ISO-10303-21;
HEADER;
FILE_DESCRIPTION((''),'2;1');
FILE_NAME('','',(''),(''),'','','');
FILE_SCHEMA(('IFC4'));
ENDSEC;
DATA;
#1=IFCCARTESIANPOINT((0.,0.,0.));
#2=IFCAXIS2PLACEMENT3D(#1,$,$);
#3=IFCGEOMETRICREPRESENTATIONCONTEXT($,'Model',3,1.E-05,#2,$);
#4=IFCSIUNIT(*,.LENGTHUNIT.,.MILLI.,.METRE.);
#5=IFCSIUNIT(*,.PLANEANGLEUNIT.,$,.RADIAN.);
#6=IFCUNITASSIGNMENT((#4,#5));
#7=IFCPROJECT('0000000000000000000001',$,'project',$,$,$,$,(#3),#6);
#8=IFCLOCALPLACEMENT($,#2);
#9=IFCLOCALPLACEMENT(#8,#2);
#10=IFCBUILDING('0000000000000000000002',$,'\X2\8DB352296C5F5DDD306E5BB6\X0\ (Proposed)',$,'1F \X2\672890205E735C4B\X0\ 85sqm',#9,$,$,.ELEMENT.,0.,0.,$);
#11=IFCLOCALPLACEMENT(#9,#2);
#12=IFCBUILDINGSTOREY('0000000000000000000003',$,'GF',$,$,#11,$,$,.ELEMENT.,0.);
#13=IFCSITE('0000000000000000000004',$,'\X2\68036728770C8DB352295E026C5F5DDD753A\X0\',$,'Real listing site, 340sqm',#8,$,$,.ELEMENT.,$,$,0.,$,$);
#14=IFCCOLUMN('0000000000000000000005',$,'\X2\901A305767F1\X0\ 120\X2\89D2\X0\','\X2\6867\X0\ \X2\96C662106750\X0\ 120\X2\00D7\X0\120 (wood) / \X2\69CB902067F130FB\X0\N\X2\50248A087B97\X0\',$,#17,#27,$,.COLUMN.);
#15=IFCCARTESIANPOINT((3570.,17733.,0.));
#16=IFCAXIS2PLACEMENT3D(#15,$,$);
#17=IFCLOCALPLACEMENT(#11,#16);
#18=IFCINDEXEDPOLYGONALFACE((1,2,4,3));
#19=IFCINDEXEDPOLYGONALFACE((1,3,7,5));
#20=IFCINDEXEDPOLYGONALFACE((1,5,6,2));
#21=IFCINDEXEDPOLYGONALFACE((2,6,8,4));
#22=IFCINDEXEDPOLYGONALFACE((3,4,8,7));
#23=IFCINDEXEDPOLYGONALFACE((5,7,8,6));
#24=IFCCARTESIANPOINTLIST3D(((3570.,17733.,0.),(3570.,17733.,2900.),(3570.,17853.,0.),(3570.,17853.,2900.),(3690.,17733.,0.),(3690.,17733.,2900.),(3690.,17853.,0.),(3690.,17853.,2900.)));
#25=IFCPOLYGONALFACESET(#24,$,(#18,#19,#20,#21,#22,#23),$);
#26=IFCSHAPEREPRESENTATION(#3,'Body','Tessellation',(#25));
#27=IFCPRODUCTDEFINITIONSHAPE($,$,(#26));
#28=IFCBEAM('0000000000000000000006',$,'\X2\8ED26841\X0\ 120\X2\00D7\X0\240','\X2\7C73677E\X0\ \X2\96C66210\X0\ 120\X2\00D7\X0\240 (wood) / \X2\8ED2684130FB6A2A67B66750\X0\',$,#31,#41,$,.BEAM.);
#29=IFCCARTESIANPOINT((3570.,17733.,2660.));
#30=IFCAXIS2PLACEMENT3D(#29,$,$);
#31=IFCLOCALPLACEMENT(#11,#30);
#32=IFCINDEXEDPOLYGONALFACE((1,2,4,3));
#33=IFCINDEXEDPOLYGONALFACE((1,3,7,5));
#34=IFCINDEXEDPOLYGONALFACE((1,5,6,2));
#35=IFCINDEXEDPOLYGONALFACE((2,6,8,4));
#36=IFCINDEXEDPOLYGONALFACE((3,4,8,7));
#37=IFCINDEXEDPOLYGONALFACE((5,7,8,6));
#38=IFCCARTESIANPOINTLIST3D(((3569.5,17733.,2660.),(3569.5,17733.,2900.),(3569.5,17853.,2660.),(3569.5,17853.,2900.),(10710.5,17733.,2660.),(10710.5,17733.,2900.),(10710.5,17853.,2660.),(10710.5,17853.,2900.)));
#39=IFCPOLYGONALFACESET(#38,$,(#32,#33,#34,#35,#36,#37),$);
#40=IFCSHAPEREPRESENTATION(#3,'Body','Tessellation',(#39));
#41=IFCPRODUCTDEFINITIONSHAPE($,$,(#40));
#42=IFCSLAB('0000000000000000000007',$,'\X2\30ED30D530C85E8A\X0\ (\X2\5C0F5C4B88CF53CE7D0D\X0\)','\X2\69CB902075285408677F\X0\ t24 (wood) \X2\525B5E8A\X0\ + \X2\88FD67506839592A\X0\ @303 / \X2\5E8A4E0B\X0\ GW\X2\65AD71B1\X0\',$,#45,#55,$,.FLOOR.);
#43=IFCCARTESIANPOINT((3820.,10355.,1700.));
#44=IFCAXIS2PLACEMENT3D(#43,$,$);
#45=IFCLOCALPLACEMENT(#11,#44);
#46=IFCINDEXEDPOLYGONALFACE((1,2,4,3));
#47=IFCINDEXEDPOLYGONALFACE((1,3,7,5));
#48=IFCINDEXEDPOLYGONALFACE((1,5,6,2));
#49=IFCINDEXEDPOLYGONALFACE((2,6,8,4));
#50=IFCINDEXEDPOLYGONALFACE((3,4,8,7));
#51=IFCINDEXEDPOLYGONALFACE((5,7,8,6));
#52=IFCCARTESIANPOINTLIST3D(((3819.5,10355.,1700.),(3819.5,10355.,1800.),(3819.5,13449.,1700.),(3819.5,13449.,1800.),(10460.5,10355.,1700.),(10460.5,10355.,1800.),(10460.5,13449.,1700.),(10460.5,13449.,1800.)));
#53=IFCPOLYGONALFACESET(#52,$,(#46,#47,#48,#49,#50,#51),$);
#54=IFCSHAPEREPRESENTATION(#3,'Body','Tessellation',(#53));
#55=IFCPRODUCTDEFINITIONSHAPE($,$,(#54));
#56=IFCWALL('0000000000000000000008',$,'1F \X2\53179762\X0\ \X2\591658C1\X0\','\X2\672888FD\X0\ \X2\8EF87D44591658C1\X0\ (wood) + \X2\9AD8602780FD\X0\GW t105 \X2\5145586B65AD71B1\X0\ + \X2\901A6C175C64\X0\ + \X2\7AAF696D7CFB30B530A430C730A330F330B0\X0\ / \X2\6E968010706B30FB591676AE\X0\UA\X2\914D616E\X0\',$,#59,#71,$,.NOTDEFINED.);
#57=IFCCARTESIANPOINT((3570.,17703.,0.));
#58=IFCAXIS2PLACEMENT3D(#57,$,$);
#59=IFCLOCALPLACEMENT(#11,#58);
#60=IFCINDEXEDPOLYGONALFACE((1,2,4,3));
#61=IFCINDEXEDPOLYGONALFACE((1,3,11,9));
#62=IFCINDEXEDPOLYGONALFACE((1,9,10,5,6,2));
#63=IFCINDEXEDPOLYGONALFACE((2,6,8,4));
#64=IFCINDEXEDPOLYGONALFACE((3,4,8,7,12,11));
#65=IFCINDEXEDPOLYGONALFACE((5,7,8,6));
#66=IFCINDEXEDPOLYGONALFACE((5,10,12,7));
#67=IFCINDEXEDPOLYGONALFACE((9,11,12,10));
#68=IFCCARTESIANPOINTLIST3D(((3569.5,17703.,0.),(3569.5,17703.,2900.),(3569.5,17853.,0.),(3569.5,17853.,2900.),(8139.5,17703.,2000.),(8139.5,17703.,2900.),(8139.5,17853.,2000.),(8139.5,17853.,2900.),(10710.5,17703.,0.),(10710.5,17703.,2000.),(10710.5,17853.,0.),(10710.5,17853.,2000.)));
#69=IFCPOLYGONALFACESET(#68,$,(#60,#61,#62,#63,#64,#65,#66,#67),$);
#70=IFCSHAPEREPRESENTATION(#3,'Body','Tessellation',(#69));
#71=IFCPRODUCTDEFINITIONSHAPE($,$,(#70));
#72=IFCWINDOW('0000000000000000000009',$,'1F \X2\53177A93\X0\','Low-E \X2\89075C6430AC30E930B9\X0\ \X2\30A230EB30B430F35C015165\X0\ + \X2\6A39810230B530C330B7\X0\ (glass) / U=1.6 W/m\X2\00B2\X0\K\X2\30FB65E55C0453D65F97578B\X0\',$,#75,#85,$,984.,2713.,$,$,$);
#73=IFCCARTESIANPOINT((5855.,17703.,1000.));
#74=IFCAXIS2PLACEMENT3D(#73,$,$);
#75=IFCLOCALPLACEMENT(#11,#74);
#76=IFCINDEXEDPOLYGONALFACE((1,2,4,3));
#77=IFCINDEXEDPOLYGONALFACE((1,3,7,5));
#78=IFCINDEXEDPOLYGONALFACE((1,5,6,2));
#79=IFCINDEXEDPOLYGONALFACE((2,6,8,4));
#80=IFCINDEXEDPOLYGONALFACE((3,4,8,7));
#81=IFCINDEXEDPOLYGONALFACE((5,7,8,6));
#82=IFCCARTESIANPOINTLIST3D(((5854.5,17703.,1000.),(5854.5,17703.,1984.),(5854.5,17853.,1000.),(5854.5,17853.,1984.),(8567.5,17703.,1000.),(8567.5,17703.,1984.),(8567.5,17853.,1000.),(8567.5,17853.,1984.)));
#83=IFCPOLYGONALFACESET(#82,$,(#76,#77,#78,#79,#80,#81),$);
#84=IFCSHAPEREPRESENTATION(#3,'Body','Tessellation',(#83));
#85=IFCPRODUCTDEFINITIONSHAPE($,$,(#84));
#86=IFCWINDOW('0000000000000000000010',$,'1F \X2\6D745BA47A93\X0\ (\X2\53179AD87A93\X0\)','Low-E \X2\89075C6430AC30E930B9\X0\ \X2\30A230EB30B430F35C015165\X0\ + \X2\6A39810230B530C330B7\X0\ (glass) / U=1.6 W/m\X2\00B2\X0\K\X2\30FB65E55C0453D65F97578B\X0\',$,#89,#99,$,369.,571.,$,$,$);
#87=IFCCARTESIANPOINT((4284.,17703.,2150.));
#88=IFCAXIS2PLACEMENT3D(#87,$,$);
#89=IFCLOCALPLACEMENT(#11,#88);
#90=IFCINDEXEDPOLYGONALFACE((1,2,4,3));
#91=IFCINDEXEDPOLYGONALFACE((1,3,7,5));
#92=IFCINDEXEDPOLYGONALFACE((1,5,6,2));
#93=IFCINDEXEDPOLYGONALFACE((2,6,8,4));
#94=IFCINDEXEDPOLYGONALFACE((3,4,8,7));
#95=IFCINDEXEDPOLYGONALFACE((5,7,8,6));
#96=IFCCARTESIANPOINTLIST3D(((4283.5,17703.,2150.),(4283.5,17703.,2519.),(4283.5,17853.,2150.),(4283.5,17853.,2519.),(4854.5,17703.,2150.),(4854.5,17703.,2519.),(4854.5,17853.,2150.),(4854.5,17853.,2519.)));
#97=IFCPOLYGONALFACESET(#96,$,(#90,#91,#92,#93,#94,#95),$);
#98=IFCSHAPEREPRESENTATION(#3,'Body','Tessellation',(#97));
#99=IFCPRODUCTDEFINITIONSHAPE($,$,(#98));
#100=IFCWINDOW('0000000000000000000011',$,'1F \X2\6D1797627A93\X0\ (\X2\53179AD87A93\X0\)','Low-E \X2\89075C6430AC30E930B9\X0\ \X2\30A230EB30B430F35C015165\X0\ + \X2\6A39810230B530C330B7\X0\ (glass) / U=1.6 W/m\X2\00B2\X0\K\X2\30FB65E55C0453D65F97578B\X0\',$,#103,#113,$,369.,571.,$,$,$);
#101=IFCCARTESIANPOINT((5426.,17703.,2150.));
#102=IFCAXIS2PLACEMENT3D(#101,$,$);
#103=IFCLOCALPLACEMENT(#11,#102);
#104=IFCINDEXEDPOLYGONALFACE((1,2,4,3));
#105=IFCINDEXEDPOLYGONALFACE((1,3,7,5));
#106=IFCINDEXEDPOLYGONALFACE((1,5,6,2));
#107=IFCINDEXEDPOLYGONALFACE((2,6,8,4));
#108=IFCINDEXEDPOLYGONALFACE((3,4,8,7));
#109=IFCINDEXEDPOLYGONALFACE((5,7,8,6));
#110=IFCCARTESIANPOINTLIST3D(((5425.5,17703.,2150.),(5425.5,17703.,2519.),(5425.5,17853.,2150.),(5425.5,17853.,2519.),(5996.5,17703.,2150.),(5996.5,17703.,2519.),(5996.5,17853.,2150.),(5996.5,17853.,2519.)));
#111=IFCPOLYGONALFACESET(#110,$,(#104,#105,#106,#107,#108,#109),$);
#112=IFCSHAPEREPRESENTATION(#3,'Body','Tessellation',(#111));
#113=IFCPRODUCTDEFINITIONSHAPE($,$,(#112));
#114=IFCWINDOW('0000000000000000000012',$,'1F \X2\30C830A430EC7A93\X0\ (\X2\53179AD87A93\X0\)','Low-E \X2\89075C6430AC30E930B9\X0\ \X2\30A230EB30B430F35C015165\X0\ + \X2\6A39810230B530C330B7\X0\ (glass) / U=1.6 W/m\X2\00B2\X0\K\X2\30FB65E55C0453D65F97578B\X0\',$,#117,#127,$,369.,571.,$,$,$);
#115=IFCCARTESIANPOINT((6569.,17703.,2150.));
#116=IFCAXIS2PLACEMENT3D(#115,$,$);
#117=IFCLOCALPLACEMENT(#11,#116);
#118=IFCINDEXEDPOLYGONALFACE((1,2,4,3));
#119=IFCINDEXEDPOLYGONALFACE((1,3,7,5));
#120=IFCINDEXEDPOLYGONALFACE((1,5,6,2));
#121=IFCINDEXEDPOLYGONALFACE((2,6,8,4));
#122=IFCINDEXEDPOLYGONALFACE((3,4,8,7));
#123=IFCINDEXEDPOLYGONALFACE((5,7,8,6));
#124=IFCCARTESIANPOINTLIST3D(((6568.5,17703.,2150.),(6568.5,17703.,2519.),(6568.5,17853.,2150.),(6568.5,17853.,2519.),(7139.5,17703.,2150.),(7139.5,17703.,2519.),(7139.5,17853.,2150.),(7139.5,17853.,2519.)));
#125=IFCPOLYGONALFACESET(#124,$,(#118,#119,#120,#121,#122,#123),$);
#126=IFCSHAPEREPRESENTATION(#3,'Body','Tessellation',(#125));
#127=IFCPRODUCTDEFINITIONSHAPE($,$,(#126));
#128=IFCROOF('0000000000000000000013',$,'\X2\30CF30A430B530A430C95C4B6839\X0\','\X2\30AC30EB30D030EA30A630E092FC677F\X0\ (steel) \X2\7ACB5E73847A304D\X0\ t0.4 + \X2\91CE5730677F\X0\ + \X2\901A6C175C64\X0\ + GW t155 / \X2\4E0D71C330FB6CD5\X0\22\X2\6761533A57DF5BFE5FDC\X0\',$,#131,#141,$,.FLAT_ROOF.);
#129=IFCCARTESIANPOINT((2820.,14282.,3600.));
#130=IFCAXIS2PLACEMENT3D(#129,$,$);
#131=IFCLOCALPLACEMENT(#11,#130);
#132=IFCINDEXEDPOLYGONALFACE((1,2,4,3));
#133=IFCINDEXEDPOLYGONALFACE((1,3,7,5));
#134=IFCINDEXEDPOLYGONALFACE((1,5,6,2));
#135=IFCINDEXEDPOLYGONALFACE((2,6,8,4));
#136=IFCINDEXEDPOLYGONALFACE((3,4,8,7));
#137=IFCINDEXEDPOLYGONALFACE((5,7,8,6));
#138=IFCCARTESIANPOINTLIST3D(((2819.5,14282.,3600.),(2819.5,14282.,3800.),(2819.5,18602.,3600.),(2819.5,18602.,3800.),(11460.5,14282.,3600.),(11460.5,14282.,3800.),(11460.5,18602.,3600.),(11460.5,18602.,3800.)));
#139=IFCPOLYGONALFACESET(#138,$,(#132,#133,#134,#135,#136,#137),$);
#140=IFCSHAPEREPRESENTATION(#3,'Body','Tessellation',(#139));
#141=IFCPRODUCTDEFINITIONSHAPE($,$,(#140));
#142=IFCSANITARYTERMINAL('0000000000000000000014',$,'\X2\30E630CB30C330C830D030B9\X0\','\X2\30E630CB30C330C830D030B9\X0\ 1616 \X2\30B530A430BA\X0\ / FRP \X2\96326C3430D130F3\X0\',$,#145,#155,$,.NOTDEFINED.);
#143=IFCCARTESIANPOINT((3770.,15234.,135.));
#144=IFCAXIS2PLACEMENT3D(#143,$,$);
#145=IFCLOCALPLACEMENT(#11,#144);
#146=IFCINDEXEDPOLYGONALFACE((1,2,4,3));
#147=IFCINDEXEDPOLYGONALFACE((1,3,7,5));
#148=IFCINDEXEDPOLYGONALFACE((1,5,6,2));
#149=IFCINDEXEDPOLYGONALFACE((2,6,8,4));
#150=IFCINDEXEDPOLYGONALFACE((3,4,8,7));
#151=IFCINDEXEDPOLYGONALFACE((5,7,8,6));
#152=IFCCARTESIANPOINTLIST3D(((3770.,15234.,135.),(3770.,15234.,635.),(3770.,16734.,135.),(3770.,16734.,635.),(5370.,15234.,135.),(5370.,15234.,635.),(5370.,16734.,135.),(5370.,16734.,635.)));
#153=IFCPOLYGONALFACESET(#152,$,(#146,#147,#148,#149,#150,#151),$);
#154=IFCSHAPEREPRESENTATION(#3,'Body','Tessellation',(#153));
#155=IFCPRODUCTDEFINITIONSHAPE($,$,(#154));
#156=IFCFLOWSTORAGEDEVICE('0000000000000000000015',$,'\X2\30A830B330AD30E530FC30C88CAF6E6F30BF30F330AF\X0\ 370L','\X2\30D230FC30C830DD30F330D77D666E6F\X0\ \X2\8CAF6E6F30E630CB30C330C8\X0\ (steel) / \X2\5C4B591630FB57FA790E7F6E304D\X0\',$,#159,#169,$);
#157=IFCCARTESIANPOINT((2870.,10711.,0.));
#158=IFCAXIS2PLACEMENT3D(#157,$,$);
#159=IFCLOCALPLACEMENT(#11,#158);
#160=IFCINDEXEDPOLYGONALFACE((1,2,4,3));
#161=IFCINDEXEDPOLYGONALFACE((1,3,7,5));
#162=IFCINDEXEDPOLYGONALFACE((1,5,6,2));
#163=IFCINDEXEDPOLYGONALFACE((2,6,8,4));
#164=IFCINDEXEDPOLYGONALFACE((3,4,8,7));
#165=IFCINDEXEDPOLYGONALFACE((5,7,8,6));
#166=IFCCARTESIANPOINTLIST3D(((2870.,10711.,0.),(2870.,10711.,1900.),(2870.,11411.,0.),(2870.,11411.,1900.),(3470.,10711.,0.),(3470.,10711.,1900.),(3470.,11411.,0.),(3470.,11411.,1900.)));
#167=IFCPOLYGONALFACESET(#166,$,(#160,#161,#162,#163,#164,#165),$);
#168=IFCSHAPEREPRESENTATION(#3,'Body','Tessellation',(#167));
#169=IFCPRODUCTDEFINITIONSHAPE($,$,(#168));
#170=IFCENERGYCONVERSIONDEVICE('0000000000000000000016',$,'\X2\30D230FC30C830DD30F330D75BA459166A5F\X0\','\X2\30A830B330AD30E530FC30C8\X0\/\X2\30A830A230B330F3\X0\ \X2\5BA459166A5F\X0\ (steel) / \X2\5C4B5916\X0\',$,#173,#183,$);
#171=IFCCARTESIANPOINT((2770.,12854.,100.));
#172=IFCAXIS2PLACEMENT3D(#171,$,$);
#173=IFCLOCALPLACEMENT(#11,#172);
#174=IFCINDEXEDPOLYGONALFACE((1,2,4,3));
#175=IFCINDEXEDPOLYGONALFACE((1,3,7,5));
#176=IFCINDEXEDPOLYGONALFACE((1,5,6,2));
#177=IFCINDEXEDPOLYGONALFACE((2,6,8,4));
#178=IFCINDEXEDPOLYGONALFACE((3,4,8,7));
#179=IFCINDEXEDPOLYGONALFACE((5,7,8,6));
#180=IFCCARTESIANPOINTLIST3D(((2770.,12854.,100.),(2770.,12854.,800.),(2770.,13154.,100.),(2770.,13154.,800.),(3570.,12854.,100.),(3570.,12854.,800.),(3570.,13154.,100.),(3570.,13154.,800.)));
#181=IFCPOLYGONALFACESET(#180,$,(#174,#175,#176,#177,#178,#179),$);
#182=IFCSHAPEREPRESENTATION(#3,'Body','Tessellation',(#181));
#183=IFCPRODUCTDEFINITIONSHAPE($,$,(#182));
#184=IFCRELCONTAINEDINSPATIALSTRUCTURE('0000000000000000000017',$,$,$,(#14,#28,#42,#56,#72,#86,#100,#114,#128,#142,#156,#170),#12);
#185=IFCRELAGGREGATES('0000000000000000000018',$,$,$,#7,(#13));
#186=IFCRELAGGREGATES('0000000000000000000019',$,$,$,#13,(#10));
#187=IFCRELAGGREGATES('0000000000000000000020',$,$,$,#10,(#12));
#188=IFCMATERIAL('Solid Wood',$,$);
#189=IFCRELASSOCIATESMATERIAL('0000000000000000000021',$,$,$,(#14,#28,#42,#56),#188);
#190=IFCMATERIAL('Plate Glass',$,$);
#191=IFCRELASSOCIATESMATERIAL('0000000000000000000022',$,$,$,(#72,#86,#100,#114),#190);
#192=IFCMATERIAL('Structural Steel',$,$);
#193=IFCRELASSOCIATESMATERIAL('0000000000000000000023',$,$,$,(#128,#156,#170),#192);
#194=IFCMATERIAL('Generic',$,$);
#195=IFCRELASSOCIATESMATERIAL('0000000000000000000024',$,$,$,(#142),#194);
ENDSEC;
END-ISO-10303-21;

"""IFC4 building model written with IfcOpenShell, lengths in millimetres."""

from ifc_helpers import new_model, si_unit, frame, frame_2d, origin, place, context, project, spatial, rectangle, extrude, material, element, fill, save


model = new_model("IFC4")

# Units and contexts
model_context = context("Model", 3, precision=1e-05, world=origin())
ifc_project = project(units=[si_unit("LENGTHUNIT", "METRE", prefix="MILLI"), si_unit("PLANEANGLEUNIT", "RADIAN")], contexts=[model_context])

# Site, building, storey
site_placement = place(None, origin())
site = spatial("IfcSite", under=ifc_project, at=site_placement, Name="栃木県足利市江川町", ObjectType="Real listing site, 340sqm", CompositionType="ELEMENT", RefElevation=0.0)
building_placement = place(site_placement, origin())
building = spatial("IfcBuilding", under=site, at=building_placement, Name="足利江川の家 (Proposed)", ObjectType="1F 木造平屋 85sqm", CompositionType="ELEMENT", ElevationOfRefHeight=0.0, ElevationOfTerrain=0.0)
storey_placement = place(building_placement, origin())
storey = spatial("IfcBuildingStorey", under=building, at=storey_placement, Name="GF", CompositionType="ELEMENT", Elevation=0.0)

# Column
ifc_material_1 = material(Name="Solid Wood")
column_1_placement = place(storey_placement, frame((3570.0, 17733.0, 0.0)))
element("IfcColumn", 1, at=column_1_placement, inside=storey, material=ifc_material_1, Name="通し柱 120角", Description="桧 集成材 120×120 (wood) / 構造柱・N値計算", PredefinedType="COLUMN", context=model_context, shape_type="SweptSolid", body=[
    extrude(rectangle(XDim=120.0, YDim=120.0, at=frame_2d((60.0, 60.0))), frame((3570.0, 17733.0, 0.0)), (0.0, 0.0, 1.0), 2900.0),
])

# Beam
beam_1_placement = place(storey_placement, frame((3570.0, 17733.0, 2660.0)))
element("IfcBeam", 2, at=beam_1_placement, inside=storey, material=ifc_material_1, Name="軒桁 120×240", Description="米松 集成 120×240 (wood) / 軒桁・横架材", PredefinedType="BEAM", context=model_context, shape_type="SweptSolid", body=[
    extrude(rectangle(XDim=7141.0, YDim=120.0, at=frame_2d((3570.0, 60.0))), frame((3570.0, 17733.0, 2660.0)), (0.0, 0.0, 1.0), 240.0),
])

# Slab
slab_placement = place(storey_placement, frame((3820.0, 10355.0, 1700.0)))
element("IfcSlab", 3, at=slab_placement, inside=storey, material=ifc_material_1, Name="ロフト床 (小屋裏収納)", Description="構造用合板 t24 (wood) 剛床 + 製材根太 @303 / 床下 GW断熱", PredefinedType="FLOOR", context=model_context, shape_type="SweptSolid", body=[
    extrude(rectangle(XDim=6641.0, YDim=3094.0, at=frame_2d((3320.0, 1547.0))), frame((3820.0, 10355.0, 1700.0)), (0.0, 0.0, 1.0), 100.0),
])

# Wall, openings, windows
wall_1_placement = place(storey_placement, frame((3570.0, 17703.0, 0.0)))
wall_1 = element("IfcWall", 4, at=wall_1_placement, inside=storey, material=ifc_material_1, Name="1F 北面 外壁", Description="木製 軸組外壁 (wood) + 高性能GW t105 充填断熱 + 通気層 + 窯業系サイディング / 準耐火・外皮UA配慮", PredefinedType="NOTDEFINED", context=model_context, shape_type="SweptSolid", body=[
    extrude(rectangle(XDim=7141.0, YDim=150.0, at=frame_2d((3570.0, 75.0))), frame((3570.0, 17703.0, 0.0)), (0.0, 0.0, 1.0), 2900.0),
])
opening_1_placement = place(storey_placement, frame((5855.0, 17703.0, 1000.0)))
opening_1 = element("IfcOpeningElement", 5, at=opening_1_placement, cuts=wall_1, PredefinedType="NOTDEFINED", context=model_context, shape_type="SweptSolid", body=[
    extrude(rectangle(XDim=2713.0, YDim=150.0, at=frame_2d((1356.0, 75.0))), frame((5855.0, 17703.0, 1000.0)), (0.0, 0.0, 1.0), 984.0),
])
opening_2_placement = place(storey_placement, frame((4284.0, 17703.0, 2150.0)))
opening_2 = element("IfcOpeningElement", 6, at=opening_2_placement, cuts=wall_1, PredefinedType="NOTDEFINED", context=model_context, shape_type="SweptSolid", body=[
    extrude(rectangle(XDim=571.0, YDim=150.0, at=frame_2d((285.0, 75.0))), frame((4284.0, 17703.0, 2150.0)), (0.0, 0.0, 1.0), 369.0),
])
opening_3_placement = place(storey_placement, frame((5426.0, 17703.0, 2150.0)))
opening_3 = element("IfcOpeningElement", 7, at=opening_3_placement, cuts=wall_1, PredefinedType="NOTDEFINED", context=model_context, shape_type="SweptSolid", body=[
    extrude(rectangle(XDim=571.0, YDim=150.0, at=frame_2d((285.0, 75.0))), frame((5426.0, 17703.0, 2150.0)), (0.0, 0.0, 1.0), 369.0),
])
opening_4_placement = place(storey_placement, frame((6569.0, 17703.0, 2150.0)))
opening_4 = element("IfcOpeningElement", 8, at=opening_4_placement, cuts=wall_1, PredefinedType="NOTDEFINED", context=model_context, shape_type="SweptSolid", body=[
    extrude(rectangle(XDim=571.0, YDim=150.0, at=frame_2d((285.0, 75.0))), frame((6569.0, 17703.0, 2150.0)), (0.0, 0.0, 1.0), 369.0),
])
ifc_material_2 = material(Name="Plate Glass")
window_1_placement = place(storey_placement, frame((5855.0, 17703.0, 1000.0)))
window_1 = element("IfcWindow", 9, at=window_1_placement, inside=storey, material=ifc_material_2, Name="1F 北窓", Description="Low-E 複層ガラス アルゴン封入 + 樹脂サッシ (glass) / U=1.6 W/m²K・日射取得型", OverallHeight=984.0, OverallWidth=2713.0, context=model_context, shape_type="SweptSolid", body=[
    extrude(rectangle(XDim=2713.0, YDim=150.0, at=frame_2d((1356.0, 75.0))), frame((5855.0, 17703.0, 1000.0)), (0.0, 0.0, 1.0), 984.0),
])
fill(opening_1, window_1)
window_2_placement = place(storey_placement, frame((4284.0, 17703.0, 2150.0)))
window_2 = element("IfcWindow", 10, at=window_2_placement, inside=storey, material=ifc_material_2, Name="1F 浴室窓 (北高窓)", Description="Low-E 複層ガラス アルゴン封入 + 樹脂サッシ (glass) / U=1.6 W/m²K・日射取得型", OverallHeight=369.0, OverallWidth=571.0, context=model_context, shape_type="SweptSolid", body=[
    extrude(rectangle(XDim=571.0, YDim=150.0, at=frame_2d((285.0, 75.0))), frame((4284.0, 17703.0, 2150.0)), (0.0, 0.0, 1.0), 369.0),
])
fill(opening_2, window_2)
window_3_placement = place(storey_placement, frame((5426.0, 17703.0, 2150.0)))
window_3 = element("IfcWindow", 11, at=window_3_placement, inside=storey, material=ifc_material_2, Name="1F 洗面窓 (北高窓)", Description="Low-E 複層ガラス アルゴン封入 + 樹脂サッシ (glass) / U=1.6 W/m²K・日射取得型", OverallHeight=369.0, OverallWidth=571.0, context=model_context, shape_type="SweptSolid", body=[
    extrude(rectangle(XDim=571.0, YDim=150.0, at=frame_2d((285.0, 75.0))), frame((5426.0, 17703.0, 2150.0)), (0.0, 0.0, 1.0), 369.0),
])
fill(opening_3, window_3)
window_4_placement = place(storey_placement, frame((6569.0, 17703.0, 2150.0)))
window_4 = element("IfcWindow", 12, at=window_4_placement, inside=storey, material=ifc_material_2, Name="1F トイレ窓 (北高窓)", Description="Low-E 複層ガラス アルゴン封入 + 樹脂サッシ (glass) / U=1.6 W/m²K・日射取得型", OverallHeight=369.0, OverallWidth=571.0, context=model_context, shape_type="SweptSolid", body=[
    extrude(rectangle(XDim=571.0, YDim=150.0, at=frame_2d((285.0, 75.0))), frame((6569.0, 17703.0, 2150.0)), (0.0, 0.0, 1.0), 369.0),
])
fill(opening_4, window_4)

# Roof
ifc_material_3 = material(Name="Structural Steel")
roof_placement = place(storey_placement, frame((2820.0, 14282.0, 3600.0)))
element("IfcRoof", 13, at=roof_placement, inside=storey, material=ifc_material_3, Name="ハイサイド屋根", Description="ガルバリウム鋼板 (steel) 立平葺き t0.4 + 野地板 + 通気層 + GW t155 / 不燃・法22条区域対応", PredefinedType="FLAT_ROOF", context=model_context, shape_type="SweptSolid", body=[
    extrude(rectangle(XDim=8641.0, YDim=4320.0, at=frame_2d((4320.0, 2160.0))), frame((2820.0, 14282.0, 3600.0)), (0.0, 0.0, 1.0), 200.0),
])

# Sanitary terminal
ifc_material_4 = material(Name="Generic")
sanitary_terminal_placement = place(storey_placement, frame((3770.0, 15234.0, 135.0)))
element("IfcSanitaryTerminal", 14, at=sanitary_terminal_placement, inside=storey, material=ifc_material_4, Name="ユニットバス", Description="ユニットバス 1616 サイズ / FRP 防水パン", PredefinedType="NOTDEFINED", context=model_context, shape_type="SweptSolid", body=[
    extrude(rectangle(XDim=1600.0, YDim=1500.0, at=frame_2d((800.0, 750.0))), frame((3770.0, 15234.0, 135.0)), (0.0, 0.0, 1.0), 500.0),
])

# Flow storage device
flow_storage_device_placement = place(storey_placement, frame((2870.0, 10711.0, 0.0)))
element("IfcFlowStorageDevice", 15, at=flow_storage_device_placement, inside=storey, material=ifc_material_3, Name="エコキュート貯湯タンク 370L", Description="ヒートポンプ給湯 貯湯ユニット (steel) / 屋外・基礎置き", context=model_context, shape_type="SweptSolid", body=[
    extrude(rectangle(XDim=600.0, YDim=700.0, at=frame_2d((300.0, 350.0))), frame((2870.0, 10711.0, 0.0)), (0.0, 0.0, 1.0), 1900.0),
])

# Energy conversion device
energy_conversion_device_placement = place(storey_placement, frame((2770.0, 12854.0, 100.0)))
element("IfcEnergyConversionDevice", 16, at=energy_conversion_device_placement, inside=storey, material=ifc_material_3, Name="ヒートポンプ室外機", Description="エコキュート/エアコン 室外機 (steel) / 屋外", context=model_context, shape_type="SweptSolid", body=[
    extrude(rectangle(XDim=800.0, YDim=300.0, at=frame_2d((400.0, 150.0))), frame((2770.0, 12854.0, 100.0)), (0.0, 0.0, 1.0), 700.0),
])

save(model, "model.ifc")
